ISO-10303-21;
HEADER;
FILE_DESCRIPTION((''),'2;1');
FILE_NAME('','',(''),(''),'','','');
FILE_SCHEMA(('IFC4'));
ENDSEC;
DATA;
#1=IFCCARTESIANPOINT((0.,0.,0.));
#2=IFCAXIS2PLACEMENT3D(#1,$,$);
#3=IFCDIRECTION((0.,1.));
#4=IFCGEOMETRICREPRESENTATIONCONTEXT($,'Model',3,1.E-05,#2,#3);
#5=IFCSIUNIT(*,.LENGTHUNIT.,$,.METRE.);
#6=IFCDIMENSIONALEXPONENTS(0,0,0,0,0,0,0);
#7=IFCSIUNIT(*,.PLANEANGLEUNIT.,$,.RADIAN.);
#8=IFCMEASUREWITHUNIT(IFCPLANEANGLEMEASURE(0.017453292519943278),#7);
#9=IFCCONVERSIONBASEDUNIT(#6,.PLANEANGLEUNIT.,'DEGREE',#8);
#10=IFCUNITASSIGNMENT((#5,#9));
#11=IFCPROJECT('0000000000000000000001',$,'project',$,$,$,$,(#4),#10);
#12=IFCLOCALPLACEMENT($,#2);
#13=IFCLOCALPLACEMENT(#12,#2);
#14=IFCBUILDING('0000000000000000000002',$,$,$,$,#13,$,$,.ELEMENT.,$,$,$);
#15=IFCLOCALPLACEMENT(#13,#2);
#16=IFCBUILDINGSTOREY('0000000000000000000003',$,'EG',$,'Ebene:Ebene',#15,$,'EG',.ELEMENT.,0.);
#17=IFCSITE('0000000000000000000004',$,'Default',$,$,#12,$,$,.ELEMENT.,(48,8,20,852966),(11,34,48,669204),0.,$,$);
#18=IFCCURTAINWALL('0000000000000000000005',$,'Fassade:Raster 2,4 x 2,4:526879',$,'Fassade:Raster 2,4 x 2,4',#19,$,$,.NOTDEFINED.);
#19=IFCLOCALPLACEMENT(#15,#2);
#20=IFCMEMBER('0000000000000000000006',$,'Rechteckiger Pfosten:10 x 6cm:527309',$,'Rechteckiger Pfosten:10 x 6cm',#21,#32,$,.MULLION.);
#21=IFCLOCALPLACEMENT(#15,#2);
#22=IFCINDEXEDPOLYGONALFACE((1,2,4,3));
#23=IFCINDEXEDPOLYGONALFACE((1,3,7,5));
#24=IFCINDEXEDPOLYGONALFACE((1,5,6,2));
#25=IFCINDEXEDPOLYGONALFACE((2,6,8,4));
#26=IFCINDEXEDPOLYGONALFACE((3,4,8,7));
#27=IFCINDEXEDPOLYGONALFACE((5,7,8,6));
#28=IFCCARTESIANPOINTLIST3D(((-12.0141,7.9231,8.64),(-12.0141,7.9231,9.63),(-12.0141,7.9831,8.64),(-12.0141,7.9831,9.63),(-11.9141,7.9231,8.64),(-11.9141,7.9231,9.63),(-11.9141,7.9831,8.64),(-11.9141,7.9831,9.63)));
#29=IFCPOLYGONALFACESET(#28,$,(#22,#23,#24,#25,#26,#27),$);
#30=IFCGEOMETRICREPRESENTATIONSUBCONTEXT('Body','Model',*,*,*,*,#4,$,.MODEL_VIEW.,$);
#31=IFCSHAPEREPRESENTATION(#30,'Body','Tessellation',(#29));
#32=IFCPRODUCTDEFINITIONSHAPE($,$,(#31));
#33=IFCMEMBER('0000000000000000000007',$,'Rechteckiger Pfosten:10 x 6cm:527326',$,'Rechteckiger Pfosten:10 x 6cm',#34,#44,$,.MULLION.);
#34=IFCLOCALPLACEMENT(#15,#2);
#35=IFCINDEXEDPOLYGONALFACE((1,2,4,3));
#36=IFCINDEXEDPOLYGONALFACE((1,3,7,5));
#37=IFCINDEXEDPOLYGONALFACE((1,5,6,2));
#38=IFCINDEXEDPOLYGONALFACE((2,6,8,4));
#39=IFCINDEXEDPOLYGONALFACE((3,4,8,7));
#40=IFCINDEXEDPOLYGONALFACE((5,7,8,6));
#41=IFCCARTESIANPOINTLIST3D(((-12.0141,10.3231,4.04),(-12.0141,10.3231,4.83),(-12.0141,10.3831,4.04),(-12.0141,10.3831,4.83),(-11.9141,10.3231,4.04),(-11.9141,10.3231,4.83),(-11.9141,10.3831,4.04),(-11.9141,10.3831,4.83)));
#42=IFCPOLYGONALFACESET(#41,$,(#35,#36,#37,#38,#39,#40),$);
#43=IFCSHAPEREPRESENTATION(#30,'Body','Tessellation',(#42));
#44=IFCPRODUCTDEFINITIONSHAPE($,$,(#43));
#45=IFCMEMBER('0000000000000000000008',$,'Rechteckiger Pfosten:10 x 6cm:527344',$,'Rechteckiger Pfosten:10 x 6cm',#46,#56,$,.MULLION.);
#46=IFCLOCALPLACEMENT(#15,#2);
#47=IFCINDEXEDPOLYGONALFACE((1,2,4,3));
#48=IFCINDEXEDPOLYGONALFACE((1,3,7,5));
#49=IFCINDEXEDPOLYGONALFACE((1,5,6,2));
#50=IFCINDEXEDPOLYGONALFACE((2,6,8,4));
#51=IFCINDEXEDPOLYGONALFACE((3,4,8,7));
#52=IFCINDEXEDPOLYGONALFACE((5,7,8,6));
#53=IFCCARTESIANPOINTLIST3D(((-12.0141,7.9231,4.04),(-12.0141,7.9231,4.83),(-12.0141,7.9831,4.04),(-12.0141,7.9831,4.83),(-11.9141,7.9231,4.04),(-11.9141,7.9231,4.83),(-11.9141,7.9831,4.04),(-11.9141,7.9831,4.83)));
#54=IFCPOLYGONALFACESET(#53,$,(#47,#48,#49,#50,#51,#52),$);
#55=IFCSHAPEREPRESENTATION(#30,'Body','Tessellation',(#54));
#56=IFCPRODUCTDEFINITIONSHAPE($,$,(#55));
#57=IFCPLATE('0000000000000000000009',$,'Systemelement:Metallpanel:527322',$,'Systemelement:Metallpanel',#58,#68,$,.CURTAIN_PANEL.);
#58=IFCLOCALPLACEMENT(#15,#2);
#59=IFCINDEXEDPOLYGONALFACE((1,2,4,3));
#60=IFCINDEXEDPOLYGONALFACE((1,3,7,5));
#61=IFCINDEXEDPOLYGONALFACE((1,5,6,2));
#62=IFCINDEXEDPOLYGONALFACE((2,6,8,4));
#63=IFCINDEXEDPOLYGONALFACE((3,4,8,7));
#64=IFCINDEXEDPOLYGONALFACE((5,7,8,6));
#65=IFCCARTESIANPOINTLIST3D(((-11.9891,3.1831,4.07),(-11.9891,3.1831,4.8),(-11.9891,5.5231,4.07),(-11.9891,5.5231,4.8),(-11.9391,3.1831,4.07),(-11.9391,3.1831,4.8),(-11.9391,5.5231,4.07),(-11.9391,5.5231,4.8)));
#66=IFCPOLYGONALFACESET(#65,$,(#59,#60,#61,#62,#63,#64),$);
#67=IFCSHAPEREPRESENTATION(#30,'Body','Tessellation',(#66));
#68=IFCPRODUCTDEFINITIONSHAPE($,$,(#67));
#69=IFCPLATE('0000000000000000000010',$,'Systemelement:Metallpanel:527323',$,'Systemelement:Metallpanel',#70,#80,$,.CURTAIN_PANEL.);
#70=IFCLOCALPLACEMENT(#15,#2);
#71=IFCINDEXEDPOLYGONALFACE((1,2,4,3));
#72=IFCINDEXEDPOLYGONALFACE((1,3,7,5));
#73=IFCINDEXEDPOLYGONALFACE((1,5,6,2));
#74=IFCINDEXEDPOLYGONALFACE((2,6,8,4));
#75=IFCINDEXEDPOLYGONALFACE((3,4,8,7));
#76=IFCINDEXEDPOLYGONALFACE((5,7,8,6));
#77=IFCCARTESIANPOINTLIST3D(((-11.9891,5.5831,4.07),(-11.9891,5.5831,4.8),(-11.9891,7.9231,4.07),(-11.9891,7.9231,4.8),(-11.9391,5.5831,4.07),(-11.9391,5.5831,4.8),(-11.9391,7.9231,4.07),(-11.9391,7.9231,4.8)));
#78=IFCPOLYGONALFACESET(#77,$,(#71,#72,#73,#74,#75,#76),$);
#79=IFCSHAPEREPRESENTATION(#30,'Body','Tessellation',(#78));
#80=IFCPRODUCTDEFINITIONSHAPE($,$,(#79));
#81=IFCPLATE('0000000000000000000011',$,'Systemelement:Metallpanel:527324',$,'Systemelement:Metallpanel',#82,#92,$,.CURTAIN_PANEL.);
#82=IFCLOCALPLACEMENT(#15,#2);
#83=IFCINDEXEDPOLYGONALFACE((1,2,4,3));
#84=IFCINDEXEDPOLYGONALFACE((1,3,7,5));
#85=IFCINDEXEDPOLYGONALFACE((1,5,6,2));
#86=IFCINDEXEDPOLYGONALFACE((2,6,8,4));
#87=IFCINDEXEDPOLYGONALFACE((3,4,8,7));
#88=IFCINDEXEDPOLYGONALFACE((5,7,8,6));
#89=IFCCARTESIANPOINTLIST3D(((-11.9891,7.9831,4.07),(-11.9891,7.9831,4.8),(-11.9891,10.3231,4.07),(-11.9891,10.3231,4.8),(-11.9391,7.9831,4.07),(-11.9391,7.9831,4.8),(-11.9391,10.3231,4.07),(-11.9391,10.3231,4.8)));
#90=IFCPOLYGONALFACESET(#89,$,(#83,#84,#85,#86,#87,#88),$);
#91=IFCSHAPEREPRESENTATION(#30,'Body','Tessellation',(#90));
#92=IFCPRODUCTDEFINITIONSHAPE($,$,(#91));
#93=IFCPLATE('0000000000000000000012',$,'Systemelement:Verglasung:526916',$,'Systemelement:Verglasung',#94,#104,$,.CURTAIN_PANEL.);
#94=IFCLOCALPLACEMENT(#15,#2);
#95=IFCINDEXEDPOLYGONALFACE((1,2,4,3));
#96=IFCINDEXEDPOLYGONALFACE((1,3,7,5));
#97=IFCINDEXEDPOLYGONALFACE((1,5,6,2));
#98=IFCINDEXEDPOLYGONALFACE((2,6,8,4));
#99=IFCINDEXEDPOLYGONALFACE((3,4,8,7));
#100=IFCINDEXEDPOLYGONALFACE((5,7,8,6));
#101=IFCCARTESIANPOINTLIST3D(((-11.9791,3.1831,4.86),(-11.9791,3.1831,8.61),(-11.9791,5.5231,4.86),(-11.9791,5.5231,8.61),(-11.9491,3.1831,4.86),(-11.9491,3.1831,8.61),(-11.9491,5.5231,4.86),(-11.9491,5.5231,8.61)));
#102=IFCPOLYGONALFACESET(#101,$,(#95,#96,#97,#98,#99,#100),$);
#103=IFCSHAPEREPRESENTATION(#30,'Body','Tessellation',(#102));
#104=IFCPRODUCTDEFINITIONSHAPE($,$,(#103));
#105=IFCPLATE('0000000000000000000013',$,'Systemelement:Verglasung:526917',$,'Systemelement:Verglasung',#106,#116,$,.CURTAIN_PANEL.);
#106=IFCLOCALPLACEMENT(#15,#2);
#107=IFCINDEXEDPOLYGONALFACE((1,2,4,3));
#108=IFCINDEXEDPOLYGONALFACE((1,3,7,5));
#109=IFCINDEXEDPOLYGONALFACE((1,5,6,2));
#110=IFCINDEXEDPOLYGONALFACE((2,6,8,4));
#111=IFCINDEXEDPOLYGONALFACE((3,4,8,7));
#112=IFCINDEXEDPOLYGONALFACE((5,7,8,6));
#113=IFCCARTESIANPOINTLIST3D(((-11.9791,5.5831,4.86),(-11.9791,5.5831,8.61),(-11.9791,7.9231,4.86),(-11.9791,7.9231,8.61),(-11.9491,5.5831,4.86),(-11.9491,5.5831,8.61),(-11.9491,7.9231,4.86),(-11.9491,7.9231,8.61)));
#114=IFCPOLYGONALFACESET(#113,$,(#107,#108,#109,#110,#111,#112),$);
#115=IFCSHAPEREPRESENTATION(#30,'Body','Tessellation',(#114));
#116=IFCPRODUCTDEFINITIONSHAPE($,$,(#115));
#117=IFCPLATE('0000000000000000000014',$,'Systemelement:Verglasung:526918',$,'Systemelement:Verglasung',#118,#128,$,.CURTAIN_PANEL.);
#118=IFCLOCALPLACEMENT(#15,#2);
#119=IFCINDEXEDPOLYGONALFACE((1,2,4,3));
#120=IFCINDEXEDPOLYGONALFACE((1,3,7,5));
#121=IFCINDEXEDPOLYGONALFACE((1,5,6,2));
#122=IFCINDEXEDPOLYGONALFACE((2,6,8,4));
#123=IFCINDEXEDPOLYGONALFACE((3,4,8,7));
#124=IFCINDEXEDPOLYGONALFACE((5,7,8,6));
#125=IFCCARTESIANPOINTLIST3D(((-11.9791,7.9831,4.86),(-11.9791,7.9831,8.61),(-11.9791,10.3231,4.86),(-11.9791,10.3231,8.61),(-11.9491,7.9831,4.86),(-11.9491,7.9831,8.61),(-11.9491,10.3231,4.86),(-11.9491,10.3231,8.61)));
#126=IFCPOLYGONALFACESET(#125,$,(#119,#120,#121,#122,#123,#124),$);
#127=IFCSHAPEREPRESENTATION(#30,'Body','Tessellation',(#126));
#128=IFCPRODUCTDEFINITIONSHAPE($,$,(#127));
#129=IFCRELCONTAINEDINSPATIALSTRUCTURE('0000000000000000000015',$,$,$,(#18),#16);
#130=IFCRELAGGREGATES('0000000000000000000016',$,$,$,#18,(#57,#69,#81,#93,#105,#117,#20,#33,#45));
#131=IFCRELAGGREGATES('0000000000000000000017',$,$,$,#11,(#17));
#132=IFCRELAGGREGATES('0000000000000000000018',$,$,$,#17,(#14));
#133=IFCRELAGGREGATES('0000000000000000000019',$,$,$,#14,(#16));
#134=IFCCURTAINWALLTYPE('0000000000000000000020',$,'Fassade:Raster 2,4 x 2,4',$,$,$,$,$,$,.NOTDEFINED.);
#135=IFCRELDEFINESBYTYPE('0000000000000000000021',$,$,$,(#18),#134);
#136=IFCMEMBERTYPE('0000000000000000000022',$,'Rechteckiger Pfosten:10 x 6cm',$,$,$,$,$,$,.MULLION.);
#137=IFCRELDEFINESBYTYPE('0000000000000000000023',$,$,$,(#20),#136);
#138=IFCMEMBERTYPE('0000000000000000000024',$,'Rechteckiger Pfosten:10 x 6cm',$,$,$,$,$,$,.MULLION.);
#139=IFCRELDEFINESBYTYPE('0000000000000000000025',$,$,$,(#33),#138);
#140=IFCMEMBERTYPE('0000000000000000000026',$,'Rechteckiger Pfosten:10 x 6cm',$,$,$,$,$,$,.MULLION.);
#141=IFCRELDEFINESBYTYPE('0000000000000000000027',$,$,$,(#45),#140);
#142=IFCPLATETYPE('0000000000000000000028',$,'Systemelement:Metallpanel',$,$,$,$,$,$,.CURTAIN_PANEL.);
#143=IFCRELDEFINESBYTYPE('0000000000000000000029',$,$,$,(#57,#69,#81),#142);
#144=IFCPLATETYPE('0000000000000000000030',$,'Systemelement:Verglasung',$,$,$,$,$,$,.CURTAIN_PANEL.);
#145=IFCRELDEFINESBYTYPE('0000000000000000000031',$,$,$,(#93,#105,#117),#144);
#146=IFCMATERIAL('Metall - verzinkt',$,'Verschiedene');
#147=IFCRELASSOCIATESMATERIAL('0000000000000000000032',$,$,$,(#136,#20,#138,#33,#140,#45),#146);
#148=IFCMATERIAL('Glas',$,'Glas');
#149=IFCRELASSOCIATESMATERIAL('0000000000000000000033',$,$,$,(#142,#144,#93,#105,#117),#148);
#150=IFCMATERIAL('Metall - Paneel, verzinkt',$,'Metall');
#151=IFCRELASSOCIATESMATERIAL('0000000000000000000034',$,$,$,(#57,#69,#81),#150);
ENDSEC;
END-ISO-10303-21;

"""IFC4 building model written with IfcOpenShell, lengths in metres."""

from ifc_helpers import new_model, entity, si_unit, converted_unit, direction, frame, origin, place, context, subcontext, project, spatial, indexed_curve, outline, extrude, source, transform, mapped, material, type_object, type_shapes, element, aggregate, save


model = new_model("IFC4")

# Units and contexts
model_context = context("Model", 3, precision=1e-05, world=origin(), true_north=direction((0.0, 1.0)))
body_context = subcontext(model_context, "Body", "Model", "MODEL_VIEW")
ifc_project = project(units=[si_unit("LENGTHUNIT", "METRE"), converted_unit("PLANEANGLEUNIT", "DEGREE", entity("IfcPlaneAngleMeasure", 0.017453292519943278), si_unit("PLANEANGLEUNIT", "RADIAN"), dimensions=[0, 0, 0, 0, 0, 0, 0])], contexts=[model_context])

# Site, building, storey
site_placement = place(None, origin())
site = spatial("IfcSite", under=ifc_project, at=site_placement, Name="Default", CompositionType="ELEMENT", RefLatitude=(48, 8, 20, 852966), RefLongitude=(11, 34, 48, 669204), RefElevation=0.0)
building_placement = place(site_placement, origin())
building = spatial("IfcBuilding", under=site, at=building_placement, CompositionType="ELEMENT")
storey_placement = place(building_placement, origin())
storey = spatial("IfcBuildingStorey", under=building, at=storey_placement, Name="EG", ObjectType="Ebene:Ebene", LongName="EG", CompositionType="ELEMENT", Elevation=0.0)

# Curtain wall, members, plates
curtain_wall_type = type_object("IfcCurtainWallType", Name="Fassade:Raster 2,4 x 2,4", PredefinedType="NOTDEFINED")
curtain_wall_placement = place(storey_placement, origin())
curtain_wall = element("IfcCurtainWall", 1, at=curtain_wall_placement, inside=storey, type_object=curtain_wall_type, Name="Fassade:Raster 2,4 x 2,4:526879", ObjectType="Fassade:Raster 2,4 x 2,4", PredefinedType="NOTDEFINED")
ifc_material_1 = material(Name="Metall - verzinkt", Category="Verschiedene")
member_type_1 = type_object("IfcMemberType", Name="Rechteckiger Pfosten:10 x 6cm", PredefinedType="MULLION", material=ifc_material_1)
shared_shape_1 = source(origin(), body_context, "Body", "SweptSolid", [
    extrude(outline(indexed_curve([(-0.03, -0.05), (0.03, -0.05), (0.03, 0.05), (-0.03, 0.05), (-0.03, -0.05)], self_intersect=False)), frame((0.0, 0.0, -0.99), z_axis=(0.0, 0.0, 1.0), x_axis=(-1.0, 0.0, 0.0)), (0.0, 0.0, 1.0), 0.99),
])
type_shapes(member_type_1, [shared_shape_1])
member_1_placement = place(curtain_wall_placement, frame((-11.9641, 7.9531, 8.64), z_axis=(0.0, 0.0, -1.0), x_axis=(0.0, 1.0, 0.0)))
member_1 = element("IfcMember", 2, at=member_1_placement, type_object=member_type_1, material=ifc_material_1, Name="Rechteckiger Pfosten:10 x 6cm:527309", ObjectType="Rechteckiger Pfosten:10 x 6cm", PredefinedType="MULLION", context=body_context, shape_type="MappedRepresentation", body=[
    mapped(shared_shape_1, transform((0.0, 0.0, 0.0), scale=1.0)),
])
member_type_2 = type_object("IfcMemberType", Name="Rechteckiger Pfosten:10 x 6cm", PredefinedType="MULLION", material=ifc_material_1)
shared_shape_2 = source(origin(), body_context, "Body", "SweptSolid", [
    extrude(outline(indexed_curve([(-0.03, -0.05), (0.03, -0.05), (0.03, 0.05), (-0.03, 0.05), (-0.03, -0.05)], self_intersect=False)), frame((-0.03, 0.0, -0.79), z_axis=(0.0, 0.0, 1.0), x_axis=(-1.0, 0.0, 0.0)), (0.0, 0.0, 1.0), 0.79),
])
type_shapes(member_type_2, [shared_shape_2])
member_2_placement = place(curtain_wall_placement, frame((-11.9641, 10.3831, 4.04), z_axis=(0.0, 0.0, -1.0), x_axis=(0.0, 1.0, 0.0)))
member_2 = element("IfcMember", 3, at=member_2_placement, type_object=member_type_2, material=ifc_material_1, Name="Rechteckiger Pfosten:10 x 6cm:527326", ObjectType="Rechteckiger Pfosten:10 x 6cm", PredefinedType="MULLION", context=body_context, shape_type="MappedRepresentation", body=[
    mapped(shared_shape_2, transform((0.0, 0.0, 0.0), scale=1.0)),
])
member_type_3 = type_object("IfcMemberType", Name="Rechteckiger Pfosten:10 x 6cm", PredefinedType="MULLION", material=ifc_material_1)
shared_shape_3 = source(origin(), body_context, "Body", "SweptSolid", [
    extrude(outline(indexed_curve([(-0.03, -0.05), (0.03, -0.05), (0.03, 0.05), (-0.03, 0.05), (-0.03, -0.05)], self_intersect=False)), frame((0.0, 0.0, -0.79), z_axis=(0.0, 0.0, 1.0), x_axis=(-1.0, 0.0, 0.0)), (0.0, 0.0, 1.0), 0.79),
])
type_shapes(member_type_3, [shared_shape_3])
member_3_placement = place(curtain_wall_placement, frame((-11.9641, 7.9531, 4.04), z_axis=(0.0, 0.0, -1.0), x_axis=(0.0, 1.0, 0.0)))
member_3 = element("IfcMember", 4, at=member_3_placement, type_object=member_type_3, material=ifc_material_1, Name="Rechteckiger Pfosten:10 x 6cm:527344", ObjectType="Rechteckiger Pfosten:10 x 6cm", PredefinedType="MULLION", context=body_context, shape_type="MappedRepresentation", body=[
    mapped(shared_shape_3, transform((0.0, 0.0, 0.0), scale=1.0)),
])
ifc_material_2 = material(Name="Metall - Paneel, verzinkt", Category="Metall")
ifc_material_3 = material(Name="Glas", Category="Glas")
plate_type_1 = type_object("IfcPlateType", Name="Systemelement:Metallpanel", PredefinedType="CURTAIN_PANEL", material=ifc_material_3)
shared_shape_4 = source(origin(), body_context, "Body", "SweptSolid", [
    extrude(outline(indexed_curve([(-0.025, -1.17), (0.025, -1.17), (0.025, 1.17), (-0.025, 1.17), (-0.025, -1.17)], self_intersect=False)), frame((0.0, 0.0, 0.0), z_axis=(0.0, 0.0, 1.0), x_axis=(0.0, 1.0, 0.0)), (0.0, 0.0, 1.0), 0.73),
])
type_shapes(plate_type_1, [shared_shape_4])
plate_1_placement = place(curtain_wall_placement, frame((-11.9641, 4.3531, 4.07), z_axis=(0.0, 0.0, 1.0), x_axis=(0.0, 1.0, 0.0)))
plate_1 = element("IfcPlate", 5, at=plate_1_placement, type_object=plate_type_1, material=ifc_material_2, Name="Systemelement:Metallpanel:527322", ObjectType="Systemelement:Metallpanel", PredefinedType="CURTAIN_PANEL", context=body_context, shape_type="MappedRepresentation", body=[
    mapped(shared_shape_4, transform((0.0, 0.0, 0.0), scale=1.0)),
])
plate_2_placement = place(curtain_wall_placement, frame((-11.9641, 6.7531, 4.07), z_axis=(0.0, 0.0, 1.0), x_axis=(0.0, 1.0, 0.0)))
plate_2 = element("IfcPlate", 6, at=plate_2_placement, type_object=plate_type_1, material=ifc_material_2, Name="Systemelement:Metallpanel:527323", ObjectType="Systemelement:Metallpanel", PredefinedType="CURTAIN_PANEL", context=body_context, shape_type="MappedRepresentation", body=[
    mapped(shared_shape_4, transform((0.0, 0.0, 0.0), scale=1.0)),
])
plate_3_placement = place(curtain_wall_placement, frame((-11.9641, 9.1531, 4.07), z_axis=(0.0, 0.0, 1.0), x_axis=(0.0, 1.0, 0.0)))
plate_3 = element("IfcPlate", 7, at=plate_3_placement, type_object=plate_type_1, material=ifc_material_2, Name="Systemelement:Metallpanel:527324", ObjectType="Systemelement:Metallpanel", PredefinedType="CURTAIN_PANEL", context=body_context, shape_type="MappedRepresentation", body=[
    mapped(shared_shape_4, transform((0.0, 0.0, 0.0), scale=1.0)),
])
plate_type_2 = type_object("IfcPlateType", Name="Systemelement:Verglasung", PredefinedType="CURTAIN_PANEL", material=ifc_material_3)
shared_shape_5 = source(origin(), body_context, "Body", "SweptSolid", [
    extrude(outline(indexed_curve([(-0.015, -1.17), (0.015, -1.17), (0.015, 1.17), (-0.015, 1.17), (-0.015, -1.17)], self_intersect=False)), frame((0.0, 0.0, 0.0), z_axis=(0.0, 0.0, 1.0), x_axis=(0.0, 1.0, 0.0)), (0.0, 0.0, 1.0), 3.75),
])
type_shapes(plate_type_2, [shared_shape_5])
plate_4_placement = place(curtain_wall_placement, frame((-11.9641, 4.3531, 4.86), z_axis=(0.0, 0.0, 1.0), x_axis=(0.0, 1.0, 0.0)))
plate_4 = element("IfcPlate", 8, at=plate_4_placement, type_object=plate_type_2, material=ifc_material_3, Name="Systemelement:Verglasung:526916", ObjectType="Systemelement:Verglasung", PredefinedType="CURTAIN_PANEL", context=body_context, shape_type="MappedRepresentation", body=[
    mapped(shared_shape_5, transform((0.0, 0.0, 0.0), scale=1.0)),
])
plate_5_placement = place(curtain_wall_placement, frame((-11.9641, 6.7531, 4.86), z_axis=(0.0, 0.0, 1.0), x_axis=(0.0, 1.0, 0.0)))
plate_5 = element("IfcPlate", 9, at=plate_5_placement, type_object=plate_type_2, material=ifc_material_3, Name="Systemelement:Verglasung:526917", ObjectType="Systemelement:Verglasung", PredefinedType="CURTAIN_PANEL", context=body_context, shape_type="MappedRepresentation", body=[
    mapped(shared_shape_5, transform((0.0, 0.0, 0.0), scale=1.0)),
])
plate_6_placement = place(curtain_wall_placement, frame((-11.9641, 9.1531, 4.86), z_axis=(0.0, 0.0, 1.0), x_axis=(0.0, 1.0, 0.0)))
plate_6 = element("IfcPlate", 10, at=plate_6_placement, type_object=plate_type_2, material=ifc_material_3, Name="Systemelement:Verglasung:526918", ObjectType="Systemelement:Verglasung", PredefinedType="CURTAIN_PANEL", context=body_context, shape_type="MappedRepresentation", body=[
    mapped(shared_shape_5, transform((0.0, 0.0, 0.0), scale=1.0)),
])
aggregate(curtain_wall, [plate_1, plate_2, plate_3, plate_4, plate_5, plate_6, member_1, member_2, member_3])

save(model, "model.ifc")
